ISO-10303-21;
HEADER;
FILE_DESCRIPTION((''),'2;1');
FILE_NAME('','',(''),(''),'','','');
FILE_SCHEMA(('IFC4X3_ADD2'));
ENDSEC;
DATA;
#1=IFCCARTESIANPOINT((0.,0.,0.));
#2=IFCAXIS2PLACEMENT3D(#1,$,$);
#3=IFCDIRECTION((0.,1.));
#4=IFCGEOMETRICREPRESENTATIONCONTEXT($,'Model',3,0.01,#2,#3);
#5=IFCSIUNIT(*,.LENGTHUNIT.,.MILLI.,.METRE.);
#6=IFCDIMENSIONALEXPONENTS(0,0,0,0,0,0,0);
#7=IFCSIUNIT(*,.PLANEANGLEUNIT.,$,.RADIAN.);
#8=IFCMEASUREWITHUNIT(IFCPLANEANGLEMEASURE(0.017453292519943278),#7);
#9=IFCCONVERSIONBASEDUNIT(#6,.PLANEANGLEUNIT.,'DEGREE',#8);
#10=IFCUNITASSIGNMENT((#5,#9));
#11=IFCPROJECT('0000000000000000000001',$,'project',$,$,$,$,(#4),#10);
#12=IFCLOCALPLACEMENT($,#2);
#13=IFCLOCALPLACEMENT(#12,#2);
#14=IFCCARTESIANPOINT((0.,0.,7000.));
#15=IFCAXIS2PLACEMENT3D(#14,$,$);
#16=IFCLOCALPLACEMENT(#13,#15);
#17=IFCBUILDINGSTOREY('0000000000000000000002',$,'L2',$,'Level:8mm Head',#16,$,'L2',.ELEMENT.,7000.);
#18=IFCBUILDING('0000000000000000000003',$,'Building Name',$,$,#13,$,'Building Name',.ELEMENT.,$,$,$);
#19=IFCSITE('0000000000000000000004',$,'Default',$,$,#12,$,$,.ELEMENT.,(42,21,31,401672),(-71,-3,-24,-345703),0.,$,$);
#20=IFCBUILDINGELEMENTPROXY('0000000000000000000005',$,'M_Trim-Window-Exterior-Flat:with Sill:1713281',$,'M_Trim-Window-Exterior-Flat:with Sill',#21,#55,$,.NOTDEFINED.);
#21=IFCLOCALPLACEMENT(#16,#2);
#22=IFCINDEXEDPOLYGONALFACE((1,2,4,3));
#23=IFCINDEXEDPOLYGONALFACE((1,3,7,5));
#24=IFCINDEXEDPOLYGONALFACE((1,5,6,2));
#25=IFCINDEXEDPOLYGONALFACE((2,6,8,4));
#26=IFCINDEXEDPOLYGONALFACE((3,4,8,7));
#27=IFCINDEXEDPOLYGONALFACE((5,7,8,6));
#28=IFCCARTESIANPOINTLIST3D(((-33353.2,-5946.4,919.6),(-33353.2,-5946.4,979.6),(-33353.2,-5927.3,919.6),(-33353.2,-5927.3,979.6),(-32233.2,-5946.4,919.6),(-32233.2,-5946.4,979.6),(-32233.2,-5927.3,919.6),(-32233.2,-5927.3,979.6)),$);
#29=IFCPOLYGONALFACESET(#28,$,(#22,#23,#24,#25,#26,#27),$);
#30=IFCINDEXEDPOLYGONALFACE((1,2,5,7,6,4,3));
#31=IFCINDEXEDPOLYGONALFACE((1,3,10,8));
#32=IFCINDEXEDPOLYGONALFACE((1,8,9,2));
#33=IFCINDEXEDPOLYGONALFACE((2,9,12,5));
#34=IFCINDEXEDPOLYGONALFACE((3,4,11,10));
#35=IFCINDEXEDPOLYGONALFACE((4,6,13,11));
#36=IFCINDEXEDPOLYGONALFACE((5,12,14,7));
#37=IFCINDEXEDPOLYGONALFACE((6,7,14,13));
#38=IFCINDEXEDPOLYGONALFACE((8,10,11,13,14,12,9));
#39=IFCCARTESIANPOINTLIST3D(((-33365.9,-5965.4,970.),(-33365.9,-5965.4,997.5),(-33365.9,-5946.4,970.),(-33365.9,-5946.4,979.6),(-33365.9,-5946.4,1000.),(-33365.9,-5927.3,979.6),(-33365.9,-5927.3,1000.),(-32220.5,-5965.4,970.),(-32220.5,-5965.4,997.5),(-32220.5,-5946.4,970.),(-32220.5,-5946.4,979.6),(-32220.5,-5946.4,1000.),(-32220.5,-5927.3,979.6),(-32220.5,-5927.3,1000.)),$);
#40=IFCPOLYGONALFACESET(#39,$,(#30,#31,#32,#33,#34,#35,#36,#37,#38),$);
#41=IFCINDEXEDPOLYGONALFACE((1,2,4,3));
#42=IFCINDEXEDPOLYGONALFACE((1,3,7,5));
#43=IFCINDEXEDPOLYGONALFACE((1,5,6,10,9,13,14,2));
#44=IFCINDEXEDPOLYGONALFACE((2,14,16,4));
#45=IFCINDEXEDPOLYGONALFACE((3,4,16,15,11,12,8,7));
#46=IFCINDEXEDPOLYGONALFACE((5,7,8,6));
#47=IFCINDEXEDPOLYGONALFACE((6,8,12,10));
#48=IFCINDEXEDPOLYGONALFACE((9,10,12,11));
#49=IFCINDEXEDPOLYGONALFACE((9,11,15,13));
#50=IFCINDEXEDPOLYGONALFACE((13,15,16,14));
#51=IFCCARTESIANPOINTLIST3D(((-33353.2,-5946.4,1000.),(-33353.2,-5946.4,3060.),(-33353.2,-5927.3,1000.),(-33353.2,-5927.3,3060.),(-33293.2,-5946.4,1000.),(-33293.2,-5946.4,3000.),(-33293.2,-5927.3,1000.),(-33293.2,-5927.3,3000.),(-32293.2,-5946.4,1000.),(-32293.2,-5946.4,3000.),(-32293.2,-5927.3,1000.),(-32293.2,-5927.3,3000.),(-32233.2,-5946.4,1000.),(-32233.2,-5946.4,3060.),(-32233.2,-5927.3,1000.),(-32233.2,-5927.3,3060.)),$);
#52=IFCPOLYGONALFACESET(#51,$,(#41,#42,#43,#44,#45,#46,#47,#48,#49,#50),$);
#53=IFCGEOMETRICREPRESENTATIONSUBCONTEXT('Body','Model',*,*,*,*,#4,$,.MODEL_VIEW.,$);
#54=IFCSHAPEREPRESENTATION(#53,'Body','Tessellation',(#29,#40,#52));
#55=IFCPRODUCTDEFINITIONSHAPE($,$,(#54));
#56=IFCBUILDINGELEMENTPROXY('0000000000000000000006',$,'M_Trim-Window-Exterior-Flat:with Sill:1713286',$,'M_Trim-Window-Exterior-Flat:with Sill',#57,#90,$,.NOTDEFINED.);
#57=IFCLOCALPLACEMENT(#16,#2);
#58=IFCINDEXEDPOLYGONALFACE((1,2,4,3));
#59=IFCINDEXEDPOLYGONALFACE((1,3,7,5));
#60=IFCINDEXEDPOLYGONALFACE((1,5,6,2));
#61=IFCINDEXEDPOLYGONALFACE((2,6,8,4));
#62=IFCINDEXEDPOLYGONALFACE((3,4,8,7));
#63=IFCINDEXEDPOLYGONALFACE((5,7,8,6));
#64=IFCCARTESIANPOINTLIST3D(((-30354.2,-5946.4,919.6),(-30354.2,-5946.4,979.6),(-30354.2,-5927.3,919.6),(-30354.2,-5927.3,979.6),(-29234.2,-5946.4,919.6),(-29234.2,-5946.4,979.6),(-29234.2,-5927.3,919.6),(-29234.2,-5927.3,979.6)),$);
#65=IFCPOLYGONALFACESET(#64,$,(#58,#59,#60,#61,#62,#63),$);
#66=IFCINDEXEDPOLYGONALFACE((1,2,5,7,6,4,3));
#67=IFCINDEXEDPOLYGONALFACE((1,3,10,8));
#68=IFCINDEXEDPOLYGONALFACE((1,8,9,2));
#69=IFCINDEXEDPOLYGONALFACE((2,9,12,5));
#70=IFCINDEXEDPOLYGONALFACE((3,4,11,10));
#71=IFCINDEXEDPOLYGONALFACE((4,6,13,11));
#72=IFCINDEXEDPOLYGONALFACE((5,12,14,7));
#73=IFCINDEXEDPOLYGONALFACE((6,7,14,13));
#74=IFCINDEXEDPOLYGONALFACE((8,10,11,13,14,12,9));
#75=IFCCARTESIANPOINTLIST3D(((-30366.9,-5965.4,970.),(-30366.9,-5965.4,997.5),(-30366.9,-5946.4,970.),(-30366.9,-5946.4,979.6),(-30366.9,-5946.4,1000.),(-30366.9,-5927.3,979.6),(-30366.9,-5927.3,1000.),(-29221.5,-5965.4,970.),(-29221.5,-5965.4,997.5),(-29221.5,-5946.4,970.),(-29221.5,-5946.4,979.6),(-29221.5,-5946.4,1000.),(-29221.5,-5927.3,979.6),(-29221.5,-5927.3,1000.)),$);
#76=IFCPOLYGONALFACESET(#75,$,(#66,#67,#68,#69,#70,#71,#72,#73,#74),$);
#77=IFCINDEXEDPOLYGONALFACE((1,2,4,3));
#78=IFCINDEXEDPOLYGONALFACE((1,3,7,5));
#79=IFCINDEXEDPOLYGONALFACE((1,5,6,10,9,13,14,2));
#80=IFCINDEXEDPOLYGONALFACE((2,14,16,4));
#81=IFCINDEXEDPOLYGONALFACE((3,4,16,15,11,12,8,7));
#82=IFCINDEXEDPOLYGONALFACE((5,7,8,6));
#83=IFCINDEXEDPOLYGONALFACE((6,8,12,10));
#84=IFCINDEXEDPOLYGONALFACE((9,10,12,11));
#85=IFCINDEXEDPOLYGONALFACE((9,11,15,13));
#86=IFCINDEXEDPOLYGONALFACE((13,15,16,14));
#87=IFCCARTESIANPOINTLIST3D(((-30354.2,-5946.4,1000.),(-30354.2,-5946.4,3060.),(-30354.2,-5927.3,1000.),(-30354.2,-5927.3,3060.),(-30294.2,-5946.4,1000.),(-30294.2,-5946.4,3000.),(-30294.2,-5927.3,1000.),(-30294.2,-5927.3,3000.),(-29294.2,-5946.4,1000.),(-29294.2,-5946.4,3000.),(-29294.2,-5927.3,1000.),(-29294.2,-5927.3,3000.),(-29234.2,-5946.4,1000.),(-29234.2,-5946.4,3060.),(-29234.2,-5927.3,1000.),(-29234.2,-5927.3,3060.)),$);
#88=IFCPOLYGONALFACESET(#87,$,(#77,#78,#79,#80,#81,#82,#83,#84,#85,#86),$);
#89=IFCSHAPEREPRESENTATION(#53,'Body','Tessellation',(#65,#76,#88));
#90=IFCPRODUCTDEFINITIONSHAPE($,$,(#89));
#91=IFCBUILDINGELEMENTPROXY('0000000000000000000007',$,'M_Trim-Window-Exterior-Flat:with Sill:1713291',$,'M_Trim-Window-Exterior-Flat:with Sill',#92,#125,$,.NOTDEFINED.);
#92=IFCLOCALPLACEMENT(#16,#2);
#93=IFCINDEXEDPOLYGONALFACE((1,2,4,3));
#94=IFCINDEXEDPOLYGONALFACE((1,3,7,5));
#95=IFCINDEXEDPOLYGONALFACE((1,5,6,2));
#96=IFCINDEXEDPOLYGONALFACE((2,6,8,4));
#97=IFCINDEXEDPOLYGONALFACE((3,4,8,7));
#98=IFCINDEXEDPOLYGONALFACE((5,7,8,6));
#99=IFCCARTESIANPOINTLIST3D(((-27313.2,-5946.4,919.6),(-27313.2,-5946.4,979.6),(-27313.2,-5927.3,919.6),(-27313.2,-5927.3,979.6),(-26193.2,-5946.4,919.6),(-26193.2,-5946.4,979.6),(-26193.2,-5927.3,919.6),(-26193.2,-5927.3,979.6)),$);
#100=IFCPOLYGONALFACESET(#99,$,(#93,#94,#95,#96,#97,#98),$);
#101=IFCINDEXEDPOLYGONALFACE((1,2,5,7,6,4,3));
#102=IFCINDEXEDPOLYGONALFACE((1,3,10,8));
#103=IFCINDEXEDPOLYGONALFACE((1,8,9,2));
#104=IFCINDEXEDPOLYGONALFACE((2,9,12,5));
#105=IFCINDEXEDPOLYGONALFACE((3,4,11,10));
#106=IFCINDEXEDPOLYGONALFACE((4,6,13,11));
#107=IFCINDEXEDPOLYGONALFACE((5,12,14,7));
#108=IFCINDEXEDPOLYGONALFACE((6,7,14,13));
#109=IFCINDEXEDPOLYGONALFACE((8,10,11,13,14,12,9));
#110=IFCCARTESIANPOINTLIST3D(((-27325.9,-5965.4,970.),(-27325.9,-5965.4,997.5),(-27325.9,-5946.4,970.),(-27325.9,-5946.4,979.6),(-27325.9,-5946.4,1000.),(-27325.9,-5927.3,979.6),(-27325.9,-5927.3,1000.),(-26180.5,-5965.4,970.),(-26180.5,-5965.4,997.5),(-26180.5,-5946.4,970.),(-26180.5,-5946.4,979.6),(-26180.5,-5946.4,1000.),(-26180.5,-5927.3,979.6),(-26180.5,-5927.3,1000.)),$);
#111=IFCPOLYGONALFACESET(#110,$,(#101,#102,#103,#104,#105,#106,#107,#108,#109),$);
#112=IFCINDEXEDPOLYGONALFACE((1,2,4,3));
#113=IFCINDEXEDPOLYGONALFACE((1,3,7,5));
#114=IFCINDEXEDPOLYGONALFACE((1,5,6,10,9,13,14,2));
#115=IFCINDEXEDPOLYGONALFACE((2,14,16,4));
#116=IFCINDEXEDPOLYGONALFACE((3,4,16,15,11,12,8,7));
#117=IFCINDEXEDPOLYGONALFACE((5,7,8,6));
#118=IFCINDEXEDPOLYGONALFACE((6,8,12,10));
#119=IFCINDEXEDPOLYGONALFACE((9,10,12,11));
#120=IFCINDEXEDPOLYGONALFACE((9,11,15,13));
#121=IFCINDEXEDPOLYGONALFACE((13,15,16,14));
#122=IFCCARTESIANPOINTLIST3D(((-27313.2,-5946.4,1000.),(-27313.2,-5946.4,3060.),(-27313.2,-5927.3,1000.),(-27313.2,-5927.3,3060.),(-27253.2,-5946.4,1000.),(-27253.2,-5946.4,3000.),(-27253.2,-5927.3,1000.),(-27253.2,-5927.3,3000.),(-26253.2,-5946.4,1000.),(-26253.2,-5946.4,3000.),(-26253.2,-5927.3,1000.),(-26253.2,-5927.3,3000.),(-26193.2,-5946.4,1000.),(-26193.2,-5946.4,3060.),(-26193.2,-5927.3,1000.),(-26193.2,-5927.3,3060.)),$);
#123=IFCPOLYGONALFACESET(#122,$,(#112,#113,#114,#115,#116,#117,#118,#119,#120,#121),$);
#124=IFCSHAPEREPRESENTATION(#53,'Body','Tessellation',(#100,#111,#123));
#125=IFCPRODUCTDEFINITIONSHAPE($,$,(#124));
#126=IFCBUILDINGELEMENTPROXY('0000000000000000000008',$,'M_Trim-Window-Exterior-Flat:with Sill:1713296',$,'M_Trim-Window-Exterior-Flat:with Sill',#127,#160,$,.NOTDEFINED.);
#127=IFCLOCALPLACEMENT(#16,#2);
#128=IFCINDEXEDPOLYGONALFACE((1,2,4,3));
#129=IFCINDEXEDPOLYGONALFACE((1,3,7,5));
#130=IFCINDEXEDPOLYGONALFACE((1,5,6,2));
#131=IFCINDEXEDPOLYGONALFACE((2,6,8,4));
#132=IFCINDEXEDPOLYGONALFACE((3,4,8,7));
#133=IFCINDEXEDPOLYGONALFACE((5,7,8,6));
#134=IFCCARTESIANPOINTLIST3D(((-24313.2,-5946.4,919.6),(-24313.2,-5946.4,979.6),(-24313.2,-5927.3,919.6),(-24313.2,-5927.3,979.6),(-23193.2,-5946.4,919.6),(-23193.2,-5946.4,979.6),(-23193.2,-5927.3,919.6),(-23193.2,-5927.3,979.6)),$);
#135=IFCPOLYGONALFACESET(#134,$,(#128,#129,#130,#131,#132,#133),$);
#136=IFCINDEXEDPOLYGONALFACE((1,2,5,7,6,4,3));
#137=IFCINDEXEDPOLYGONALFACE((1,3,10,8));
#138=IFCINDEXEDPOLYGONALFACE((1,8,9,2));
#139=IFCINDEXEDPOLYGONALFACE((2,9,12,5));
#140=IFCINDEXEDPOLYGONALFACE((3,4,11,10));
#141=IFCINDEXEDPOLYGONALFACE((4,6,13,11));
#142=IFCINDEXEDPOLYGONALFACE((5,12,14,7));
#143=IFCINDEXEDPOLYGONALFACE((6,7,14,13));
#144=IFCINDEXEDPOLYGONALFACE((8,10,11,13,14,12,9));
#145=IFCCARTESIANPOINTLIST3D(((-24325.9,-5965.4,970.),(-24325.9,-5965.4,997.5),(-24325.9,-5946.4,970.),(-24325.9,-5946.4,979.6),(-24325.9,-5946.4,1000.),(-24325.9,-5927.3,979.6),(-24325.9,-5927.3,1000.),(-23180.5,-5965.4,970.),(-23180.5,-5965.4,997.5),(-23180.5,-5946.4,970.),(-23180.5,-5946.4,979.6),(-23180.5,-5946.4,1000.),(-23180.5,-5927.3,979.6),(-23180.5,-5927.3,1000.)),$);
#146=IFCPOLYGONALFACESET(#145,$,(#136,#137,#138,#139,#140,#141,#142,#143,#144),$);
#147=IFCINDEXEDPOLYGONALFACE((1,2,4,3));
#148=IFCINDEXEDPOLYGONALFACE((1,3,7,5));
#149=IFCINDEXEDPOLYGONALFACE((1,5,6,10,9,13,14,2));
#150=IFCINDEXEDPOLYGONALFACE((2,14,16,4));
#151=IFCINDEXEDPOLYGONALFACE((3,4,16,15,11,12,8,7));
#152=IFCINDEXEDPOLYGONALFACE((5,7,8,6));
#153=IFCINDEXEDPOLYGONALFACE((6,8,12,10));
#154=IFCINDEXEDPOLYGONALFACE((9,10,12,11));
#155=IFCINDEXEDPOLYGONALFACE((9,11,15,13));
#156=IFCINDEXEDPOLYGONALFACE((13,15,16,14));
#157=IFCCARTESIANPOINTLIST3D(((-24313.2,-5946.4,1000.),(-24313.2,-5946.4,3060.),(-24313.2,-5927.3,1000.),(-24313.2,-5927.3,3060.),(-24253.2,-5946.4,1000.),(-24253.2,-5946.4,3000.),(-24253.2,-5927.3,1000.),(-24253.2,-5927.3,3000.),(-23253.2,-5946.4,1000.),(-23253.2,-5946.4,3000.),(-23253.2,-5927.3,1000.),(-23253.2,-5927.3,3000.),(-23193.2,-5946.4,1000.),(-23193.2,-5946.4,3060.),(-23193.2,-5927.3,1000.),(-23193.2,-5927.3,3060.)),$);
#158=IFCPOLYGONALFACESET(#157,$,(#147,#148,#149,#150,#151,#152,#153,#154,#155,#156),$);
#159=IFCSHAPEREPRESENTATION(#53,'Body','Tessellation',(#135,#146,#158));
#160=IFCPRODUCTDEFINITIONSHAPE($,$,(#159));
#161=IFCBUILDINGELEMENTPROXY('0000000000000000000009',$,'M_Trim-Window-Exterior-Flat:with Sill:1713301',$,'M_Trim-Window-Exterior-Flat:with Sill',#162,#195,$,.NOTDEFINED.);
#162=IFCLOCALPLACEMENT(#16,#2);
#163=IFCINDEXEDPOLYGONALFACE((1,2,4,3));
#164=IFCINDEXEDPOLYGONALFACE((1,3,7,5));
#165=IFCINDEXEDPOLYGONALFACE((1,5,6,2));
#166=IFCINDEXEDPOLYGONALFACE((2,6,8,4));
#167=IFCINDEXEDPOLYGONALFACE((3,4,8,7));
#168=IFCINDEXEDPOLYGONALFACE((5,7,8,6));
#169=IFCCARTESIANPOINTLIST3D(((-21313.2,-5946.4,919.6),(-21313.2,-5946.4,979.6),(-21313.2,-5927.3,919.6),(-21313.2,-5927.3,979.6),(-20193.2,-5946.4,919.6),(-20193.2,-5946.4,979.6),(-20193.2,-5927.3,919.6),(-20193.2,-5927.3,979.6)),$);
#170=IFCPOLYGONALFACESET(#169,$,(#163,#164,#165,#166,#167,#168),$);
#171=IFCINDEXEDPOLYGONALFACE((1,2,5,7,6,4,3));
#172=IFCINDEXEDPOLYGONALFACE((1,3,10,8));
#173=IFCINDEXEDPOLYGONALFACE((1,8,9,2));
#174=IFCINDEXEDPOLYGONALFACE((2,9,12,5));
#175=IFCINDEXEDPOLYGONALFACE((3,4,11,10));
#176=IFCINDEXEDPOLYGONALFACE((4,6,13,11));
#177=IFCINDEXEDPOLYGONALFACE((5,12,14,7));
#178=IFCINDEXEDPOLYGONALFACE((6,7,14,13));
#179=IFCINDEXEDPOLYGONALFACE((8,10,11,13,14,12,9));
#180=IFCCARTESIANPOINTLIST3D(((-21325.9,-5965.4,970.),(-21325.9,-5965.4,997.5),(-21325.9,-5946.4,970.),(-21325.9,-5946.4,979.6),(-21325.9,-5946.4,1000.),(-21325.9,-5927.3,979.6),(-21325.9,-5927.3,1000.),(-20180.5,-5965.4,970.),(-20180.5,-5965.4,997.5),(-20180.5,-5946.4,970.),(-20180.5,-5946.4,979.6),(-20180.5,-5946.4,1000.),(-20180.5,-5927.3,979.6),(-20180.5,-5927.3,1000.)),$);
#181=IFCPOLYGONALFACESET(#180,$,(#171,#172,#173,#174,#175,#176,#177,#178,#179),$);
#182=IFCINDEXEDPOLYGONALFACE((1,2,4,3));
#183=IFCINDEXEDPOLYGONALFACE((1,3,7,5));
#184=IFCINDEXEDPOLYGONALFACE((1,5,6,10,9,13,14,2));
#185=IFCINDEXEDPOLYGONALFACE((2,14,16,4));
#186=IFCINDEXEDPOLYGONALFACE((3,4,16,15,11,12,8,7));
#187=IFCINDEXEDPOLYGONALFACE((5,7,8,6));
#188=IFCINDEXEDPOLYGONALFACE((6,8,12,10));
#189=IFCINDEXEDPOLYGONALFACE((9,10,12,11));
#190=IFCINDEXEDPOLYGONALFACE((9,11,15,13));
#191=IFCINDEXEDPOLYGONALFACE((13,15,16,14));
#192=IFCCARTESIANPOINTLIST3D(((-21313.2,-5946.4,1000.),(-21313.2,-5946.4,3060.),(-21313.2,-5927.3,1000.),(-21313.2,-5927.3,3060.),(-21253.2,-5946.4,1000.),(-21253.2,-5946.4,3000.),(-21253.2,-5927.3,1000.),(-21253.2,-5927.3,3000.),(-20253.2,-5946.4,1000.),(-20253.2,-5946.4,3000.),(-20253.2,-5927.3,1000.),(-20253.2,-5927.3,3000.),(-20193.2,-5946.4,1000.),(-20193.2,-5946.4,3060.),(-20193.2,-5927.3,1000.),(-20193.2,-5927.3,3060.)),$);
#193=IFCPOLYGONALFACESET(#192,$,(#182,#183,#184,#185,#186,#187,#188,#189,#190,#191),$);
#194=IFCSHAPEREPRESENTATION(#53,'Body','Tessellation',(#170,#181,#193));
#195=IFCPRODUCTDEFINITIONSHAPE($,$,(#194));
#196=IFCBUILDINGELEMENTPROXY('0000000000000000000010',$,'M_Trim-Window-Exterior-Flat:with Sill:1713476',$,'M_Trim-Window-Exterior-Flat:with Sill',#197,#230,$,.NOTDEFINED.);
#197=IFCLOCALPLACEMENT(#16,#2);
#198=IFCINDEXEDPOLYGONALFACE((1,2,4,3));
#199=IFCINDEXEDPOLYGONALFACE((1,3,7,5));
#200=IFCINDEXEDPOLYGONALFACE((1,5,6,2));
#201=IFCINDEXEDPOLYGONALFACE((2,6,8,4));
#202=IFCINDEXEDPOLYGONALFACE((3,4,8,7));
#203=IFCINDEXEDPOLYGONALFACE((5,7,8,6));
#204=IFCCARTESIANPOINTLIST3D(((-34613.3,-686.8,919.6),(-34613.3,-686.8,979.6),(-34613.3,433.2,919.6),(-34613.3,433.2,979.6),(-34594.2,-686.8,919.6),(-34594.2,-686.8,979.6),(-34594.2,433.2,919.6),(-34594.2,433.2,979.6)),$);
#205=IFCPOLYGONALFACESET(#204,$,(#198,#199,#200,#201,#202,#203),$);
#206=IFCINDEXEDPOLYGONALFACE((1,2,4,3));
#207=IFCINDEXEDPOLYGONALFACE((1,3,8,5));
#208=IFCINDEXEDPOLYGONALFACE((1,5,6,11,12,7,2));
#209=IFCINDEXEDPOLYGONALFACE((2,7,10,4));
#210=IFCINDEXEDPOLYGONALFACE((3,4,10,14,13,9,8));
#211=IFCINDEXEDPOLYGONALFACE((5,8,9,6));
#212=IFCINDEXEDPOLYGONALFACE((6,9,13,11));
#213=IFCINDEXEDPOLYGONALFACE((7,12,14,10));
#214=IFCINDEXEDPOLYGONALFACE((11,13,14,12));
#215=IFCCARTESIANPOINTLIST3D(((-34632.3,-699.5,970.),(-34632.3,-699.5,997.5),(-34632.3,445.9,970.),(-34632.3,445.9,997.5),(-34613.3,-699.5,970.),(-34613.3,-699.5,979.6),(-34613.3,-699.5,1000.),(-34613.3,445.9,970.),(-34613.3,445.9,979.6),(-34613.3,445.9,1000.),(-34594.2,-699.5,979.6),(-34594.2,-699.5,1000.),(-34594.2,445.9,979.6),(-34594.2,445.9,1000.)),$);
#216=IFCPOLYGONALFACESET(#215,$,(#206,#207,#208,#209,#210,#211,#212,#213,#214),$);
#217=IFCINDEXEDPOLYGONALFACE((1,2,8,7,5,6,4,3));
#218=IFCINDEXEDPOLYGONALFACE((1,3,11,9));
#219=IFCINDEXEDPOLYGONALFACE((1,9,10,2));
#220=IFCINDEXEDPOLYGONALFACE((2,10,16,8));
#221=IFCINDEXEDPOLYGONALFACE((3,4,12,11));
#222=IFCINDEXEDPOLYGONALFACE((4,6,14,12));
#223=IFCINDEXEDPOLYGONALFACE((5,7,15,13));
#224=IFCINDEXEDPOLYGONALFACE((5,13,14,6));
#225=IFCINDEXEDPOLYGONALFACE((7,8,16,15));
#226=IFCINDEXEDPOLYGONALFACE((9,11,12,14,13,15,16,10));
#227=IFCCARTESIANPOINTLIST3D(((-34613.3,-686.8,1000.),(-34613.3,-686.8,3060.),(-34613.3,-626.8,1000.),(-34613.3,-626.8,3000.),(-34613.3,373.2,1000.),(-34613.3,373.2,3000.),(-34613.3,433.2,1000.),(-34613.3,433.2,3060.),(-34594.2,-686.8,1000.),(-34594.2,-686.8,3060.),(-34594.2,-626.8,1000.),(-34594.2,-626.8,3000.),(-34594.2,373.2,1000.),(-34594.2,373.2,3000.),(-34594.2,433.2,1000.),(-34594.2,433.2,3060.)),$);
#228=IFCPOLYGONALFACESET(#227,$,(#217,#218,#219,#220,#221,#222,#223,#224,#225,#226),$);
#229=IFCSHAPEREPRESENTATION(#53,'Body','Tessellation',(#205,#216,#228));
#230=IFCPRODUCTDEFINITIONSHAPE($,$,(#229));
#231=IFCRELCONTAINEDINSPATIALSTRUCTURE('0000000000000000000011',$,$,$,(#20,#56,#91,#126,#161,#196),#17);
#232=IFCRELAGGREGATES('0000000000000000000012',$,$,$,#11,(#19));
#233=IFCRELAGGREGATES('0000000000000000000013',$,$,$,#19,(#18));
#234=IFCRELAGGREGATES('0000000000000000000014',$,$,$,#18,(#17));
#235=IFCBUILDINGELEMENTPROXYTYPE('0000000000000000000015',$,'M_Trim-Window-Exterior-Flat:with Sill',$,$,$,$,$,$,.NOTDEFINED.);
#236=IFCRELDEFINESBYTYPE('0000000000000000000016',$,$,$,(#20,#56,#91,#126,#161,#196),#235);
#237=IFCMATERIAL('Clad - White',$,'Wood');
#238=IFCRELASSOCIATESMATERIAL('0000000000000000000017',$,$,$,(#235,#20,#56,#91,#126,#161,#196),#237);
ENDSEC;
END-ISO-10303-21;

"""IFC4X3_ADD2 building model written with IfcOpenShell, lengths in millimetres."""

from ifc_helpers import new_model, entity, si_unit, converted_unit, direction, frame, frame_2d, origin, place, context, subcontext, project, spatial, polyline, rectangle, outline, extrude, source, transform, mapped, material, type_object, type_shapes, element, save


model = new_model("IFC4X3_ADD2")

# Units and contexts
model_context = context("Model", 3, precision=0.01, world=origin(), true_north=direction((0.0, 1.0)))
body_context = subcontext(model_context, "Body", "Model", "MODEL_VIEW")
ifc_project = project(units=[si_unit("LENGTHUNIT", "METRE", prefix="MILLI"), converted_unit("PLANEANGLEUNIT", "DEGREE", entity("IfcPlaneAngleMeasure", 0.017453292519943278), si_unit("PLANEANGLEUNIT", "RADIAN"), dimensions=[0, 0, 0, 0, 0, 0, 0])], contexts=[model_context])

# Site, building, storey
site_placement = place(None, origin())
site = spatial("IfcSite", under=ifc_project, at=site_placement, Name="Default", CompositionType="ELEMENT", RefLatitude=(42, 21, 31, 401672), RefLongitude=(-71, -3, -24, -345703), RefElevation=0.0)
building_placement = place(site_placement, origin())
building = spatial("IfcBuilding", under=site, at=building_placement, Name="Building Name", LongName="Building Name", CompositionType="ELEMENT")
storey_placement = place(building_placement, frame((0.0, 0.0, 7000.0)))
storey = spatial("IfcBuildingStorey", under=building, at=storey_placement, Name="L2", ObjectType="Level:8mm Head", LongName="L2", CompositionType="ELEMENT", Elevation=7000.0)

# Building element proxies
ifc_material_1 = material(Name="Clad - White", Category="Wood")
building_element_proxy_type_1 = type_object("IfcBuildingElementProxyType", Name="M_Trim-Window-Exterior-Flat:with Sill", PredefinedType="NOTDEFINED", material=ifc_material_1)
shared_shape_1 = source(origin(), body_context, "Body", "SweptSolid", [
    extrude(rectangle(XDim=1120.0, YDim=60.0, at=frame_2d((0.0, 0.0), x_axis=(1.0, 0.0))), frame((0.0, -2050.4, 0.0), z_axis=(0.0, 0.0, 1.0), x_axis=(-1.0, 0.0, 0.0)), (0.0, 0.0, 1.0), 19.0),
    extrude(outline(polyline([(-19.0, -15.2), (0.0, -15.2), (0.0, -5.7), (19.0, -5.7), (19.0, 14.8), (0.0, 14.8), (-19.0, 12.3), (-19.0, -15.2)])), frame((-572.7, -2014.8, 19.0), z_axis=(1.0, 0.0, 0.0), x_axis=(0.0, 0.0, -1.0)), (0.0, 0.0, 1.0), 1145.4),
    extrude(outline(polyline([(-1045.0, -560.0), (1015.0, -560.0), (1015.0, -500.0), (-985.0, -500.0), (-985.0, 500.0), (1015.0, 500.0), (1015.0, 560.0), (-1045.0, 560.0), (-1045.0, -560.0)])), frame((0.0, -985.0, 0.0), z_axis=(0.0, 0.0, 1.0), x_axis=(0.0, -1.0, 0.0)), (0.0, 0.0, 1.0), 19.0),
])
type_shapes(building_element_proxy_type_1, [shared_shape_1])
for number, where, z_axis, x_axis, name in (
    (1, (-32793.2, -5927.3, 3000.0), (0.0, -1.0, 0.0), (1.0, 0.0, 0.0), "M_Trim-Window-Exterior-Flat:with Sill:1713281"),
    (2, (-29794.2, -5927.3, 3000.0), (0.0, -1.0, 0.0), (1.0, 0.0, 0.0), "M_Trim-Window-Exterior-Flat:with Sill:1713286"),
    (3, (-26753.2, -5927.3, 3000.0), (0.0, -1.0, 0.0), (1.0, 0.0, 0.0), "M_Trim-Window-Exterior-Flat:with Sill:1713291"),
    (4, (-23753.2, -5927.3, 3000.0), (0.0, -1.0, 0.0), (1.0, 0.0, 0.0), "M_Trim-Window-Exterior-Flat:with Sill:1713296"),
    (5, (-20753.2, -5927.3, 3000.0), (0.0, -1.0, 0.0), (1.0, 0.0, 0.0), "M_Trim-Window-Exterior-Flat:with Sill:1713301"),
    (6, (-34594.2, -126.8, 3000.0), (-1.0, 0.0, 0.0), (0.0, -1.0, 0.0), "M_Trim-Window-Exterior-Flat:with Sill:1713476"),
):
    element("IfcBuildingElementProxy", number, at=place(storey_placement, frame(where, z_axis=z_axis, x_axis=x_axis)), inside=storey, type_object=building_element_proxy_type_1, material=ifc_material_1, Name=name, ObjectType="M_Trim-Window-Exterior-Flat:with Sill", PredefinedType="NOTDEFINED", context=body_context, shape_type="MappedRepresentation", body=[
        mapped(shared_shape_1, transform((0.0, 0.0, 0.0), scale=1.0)),
    ])

save(model, "model.ifc")
